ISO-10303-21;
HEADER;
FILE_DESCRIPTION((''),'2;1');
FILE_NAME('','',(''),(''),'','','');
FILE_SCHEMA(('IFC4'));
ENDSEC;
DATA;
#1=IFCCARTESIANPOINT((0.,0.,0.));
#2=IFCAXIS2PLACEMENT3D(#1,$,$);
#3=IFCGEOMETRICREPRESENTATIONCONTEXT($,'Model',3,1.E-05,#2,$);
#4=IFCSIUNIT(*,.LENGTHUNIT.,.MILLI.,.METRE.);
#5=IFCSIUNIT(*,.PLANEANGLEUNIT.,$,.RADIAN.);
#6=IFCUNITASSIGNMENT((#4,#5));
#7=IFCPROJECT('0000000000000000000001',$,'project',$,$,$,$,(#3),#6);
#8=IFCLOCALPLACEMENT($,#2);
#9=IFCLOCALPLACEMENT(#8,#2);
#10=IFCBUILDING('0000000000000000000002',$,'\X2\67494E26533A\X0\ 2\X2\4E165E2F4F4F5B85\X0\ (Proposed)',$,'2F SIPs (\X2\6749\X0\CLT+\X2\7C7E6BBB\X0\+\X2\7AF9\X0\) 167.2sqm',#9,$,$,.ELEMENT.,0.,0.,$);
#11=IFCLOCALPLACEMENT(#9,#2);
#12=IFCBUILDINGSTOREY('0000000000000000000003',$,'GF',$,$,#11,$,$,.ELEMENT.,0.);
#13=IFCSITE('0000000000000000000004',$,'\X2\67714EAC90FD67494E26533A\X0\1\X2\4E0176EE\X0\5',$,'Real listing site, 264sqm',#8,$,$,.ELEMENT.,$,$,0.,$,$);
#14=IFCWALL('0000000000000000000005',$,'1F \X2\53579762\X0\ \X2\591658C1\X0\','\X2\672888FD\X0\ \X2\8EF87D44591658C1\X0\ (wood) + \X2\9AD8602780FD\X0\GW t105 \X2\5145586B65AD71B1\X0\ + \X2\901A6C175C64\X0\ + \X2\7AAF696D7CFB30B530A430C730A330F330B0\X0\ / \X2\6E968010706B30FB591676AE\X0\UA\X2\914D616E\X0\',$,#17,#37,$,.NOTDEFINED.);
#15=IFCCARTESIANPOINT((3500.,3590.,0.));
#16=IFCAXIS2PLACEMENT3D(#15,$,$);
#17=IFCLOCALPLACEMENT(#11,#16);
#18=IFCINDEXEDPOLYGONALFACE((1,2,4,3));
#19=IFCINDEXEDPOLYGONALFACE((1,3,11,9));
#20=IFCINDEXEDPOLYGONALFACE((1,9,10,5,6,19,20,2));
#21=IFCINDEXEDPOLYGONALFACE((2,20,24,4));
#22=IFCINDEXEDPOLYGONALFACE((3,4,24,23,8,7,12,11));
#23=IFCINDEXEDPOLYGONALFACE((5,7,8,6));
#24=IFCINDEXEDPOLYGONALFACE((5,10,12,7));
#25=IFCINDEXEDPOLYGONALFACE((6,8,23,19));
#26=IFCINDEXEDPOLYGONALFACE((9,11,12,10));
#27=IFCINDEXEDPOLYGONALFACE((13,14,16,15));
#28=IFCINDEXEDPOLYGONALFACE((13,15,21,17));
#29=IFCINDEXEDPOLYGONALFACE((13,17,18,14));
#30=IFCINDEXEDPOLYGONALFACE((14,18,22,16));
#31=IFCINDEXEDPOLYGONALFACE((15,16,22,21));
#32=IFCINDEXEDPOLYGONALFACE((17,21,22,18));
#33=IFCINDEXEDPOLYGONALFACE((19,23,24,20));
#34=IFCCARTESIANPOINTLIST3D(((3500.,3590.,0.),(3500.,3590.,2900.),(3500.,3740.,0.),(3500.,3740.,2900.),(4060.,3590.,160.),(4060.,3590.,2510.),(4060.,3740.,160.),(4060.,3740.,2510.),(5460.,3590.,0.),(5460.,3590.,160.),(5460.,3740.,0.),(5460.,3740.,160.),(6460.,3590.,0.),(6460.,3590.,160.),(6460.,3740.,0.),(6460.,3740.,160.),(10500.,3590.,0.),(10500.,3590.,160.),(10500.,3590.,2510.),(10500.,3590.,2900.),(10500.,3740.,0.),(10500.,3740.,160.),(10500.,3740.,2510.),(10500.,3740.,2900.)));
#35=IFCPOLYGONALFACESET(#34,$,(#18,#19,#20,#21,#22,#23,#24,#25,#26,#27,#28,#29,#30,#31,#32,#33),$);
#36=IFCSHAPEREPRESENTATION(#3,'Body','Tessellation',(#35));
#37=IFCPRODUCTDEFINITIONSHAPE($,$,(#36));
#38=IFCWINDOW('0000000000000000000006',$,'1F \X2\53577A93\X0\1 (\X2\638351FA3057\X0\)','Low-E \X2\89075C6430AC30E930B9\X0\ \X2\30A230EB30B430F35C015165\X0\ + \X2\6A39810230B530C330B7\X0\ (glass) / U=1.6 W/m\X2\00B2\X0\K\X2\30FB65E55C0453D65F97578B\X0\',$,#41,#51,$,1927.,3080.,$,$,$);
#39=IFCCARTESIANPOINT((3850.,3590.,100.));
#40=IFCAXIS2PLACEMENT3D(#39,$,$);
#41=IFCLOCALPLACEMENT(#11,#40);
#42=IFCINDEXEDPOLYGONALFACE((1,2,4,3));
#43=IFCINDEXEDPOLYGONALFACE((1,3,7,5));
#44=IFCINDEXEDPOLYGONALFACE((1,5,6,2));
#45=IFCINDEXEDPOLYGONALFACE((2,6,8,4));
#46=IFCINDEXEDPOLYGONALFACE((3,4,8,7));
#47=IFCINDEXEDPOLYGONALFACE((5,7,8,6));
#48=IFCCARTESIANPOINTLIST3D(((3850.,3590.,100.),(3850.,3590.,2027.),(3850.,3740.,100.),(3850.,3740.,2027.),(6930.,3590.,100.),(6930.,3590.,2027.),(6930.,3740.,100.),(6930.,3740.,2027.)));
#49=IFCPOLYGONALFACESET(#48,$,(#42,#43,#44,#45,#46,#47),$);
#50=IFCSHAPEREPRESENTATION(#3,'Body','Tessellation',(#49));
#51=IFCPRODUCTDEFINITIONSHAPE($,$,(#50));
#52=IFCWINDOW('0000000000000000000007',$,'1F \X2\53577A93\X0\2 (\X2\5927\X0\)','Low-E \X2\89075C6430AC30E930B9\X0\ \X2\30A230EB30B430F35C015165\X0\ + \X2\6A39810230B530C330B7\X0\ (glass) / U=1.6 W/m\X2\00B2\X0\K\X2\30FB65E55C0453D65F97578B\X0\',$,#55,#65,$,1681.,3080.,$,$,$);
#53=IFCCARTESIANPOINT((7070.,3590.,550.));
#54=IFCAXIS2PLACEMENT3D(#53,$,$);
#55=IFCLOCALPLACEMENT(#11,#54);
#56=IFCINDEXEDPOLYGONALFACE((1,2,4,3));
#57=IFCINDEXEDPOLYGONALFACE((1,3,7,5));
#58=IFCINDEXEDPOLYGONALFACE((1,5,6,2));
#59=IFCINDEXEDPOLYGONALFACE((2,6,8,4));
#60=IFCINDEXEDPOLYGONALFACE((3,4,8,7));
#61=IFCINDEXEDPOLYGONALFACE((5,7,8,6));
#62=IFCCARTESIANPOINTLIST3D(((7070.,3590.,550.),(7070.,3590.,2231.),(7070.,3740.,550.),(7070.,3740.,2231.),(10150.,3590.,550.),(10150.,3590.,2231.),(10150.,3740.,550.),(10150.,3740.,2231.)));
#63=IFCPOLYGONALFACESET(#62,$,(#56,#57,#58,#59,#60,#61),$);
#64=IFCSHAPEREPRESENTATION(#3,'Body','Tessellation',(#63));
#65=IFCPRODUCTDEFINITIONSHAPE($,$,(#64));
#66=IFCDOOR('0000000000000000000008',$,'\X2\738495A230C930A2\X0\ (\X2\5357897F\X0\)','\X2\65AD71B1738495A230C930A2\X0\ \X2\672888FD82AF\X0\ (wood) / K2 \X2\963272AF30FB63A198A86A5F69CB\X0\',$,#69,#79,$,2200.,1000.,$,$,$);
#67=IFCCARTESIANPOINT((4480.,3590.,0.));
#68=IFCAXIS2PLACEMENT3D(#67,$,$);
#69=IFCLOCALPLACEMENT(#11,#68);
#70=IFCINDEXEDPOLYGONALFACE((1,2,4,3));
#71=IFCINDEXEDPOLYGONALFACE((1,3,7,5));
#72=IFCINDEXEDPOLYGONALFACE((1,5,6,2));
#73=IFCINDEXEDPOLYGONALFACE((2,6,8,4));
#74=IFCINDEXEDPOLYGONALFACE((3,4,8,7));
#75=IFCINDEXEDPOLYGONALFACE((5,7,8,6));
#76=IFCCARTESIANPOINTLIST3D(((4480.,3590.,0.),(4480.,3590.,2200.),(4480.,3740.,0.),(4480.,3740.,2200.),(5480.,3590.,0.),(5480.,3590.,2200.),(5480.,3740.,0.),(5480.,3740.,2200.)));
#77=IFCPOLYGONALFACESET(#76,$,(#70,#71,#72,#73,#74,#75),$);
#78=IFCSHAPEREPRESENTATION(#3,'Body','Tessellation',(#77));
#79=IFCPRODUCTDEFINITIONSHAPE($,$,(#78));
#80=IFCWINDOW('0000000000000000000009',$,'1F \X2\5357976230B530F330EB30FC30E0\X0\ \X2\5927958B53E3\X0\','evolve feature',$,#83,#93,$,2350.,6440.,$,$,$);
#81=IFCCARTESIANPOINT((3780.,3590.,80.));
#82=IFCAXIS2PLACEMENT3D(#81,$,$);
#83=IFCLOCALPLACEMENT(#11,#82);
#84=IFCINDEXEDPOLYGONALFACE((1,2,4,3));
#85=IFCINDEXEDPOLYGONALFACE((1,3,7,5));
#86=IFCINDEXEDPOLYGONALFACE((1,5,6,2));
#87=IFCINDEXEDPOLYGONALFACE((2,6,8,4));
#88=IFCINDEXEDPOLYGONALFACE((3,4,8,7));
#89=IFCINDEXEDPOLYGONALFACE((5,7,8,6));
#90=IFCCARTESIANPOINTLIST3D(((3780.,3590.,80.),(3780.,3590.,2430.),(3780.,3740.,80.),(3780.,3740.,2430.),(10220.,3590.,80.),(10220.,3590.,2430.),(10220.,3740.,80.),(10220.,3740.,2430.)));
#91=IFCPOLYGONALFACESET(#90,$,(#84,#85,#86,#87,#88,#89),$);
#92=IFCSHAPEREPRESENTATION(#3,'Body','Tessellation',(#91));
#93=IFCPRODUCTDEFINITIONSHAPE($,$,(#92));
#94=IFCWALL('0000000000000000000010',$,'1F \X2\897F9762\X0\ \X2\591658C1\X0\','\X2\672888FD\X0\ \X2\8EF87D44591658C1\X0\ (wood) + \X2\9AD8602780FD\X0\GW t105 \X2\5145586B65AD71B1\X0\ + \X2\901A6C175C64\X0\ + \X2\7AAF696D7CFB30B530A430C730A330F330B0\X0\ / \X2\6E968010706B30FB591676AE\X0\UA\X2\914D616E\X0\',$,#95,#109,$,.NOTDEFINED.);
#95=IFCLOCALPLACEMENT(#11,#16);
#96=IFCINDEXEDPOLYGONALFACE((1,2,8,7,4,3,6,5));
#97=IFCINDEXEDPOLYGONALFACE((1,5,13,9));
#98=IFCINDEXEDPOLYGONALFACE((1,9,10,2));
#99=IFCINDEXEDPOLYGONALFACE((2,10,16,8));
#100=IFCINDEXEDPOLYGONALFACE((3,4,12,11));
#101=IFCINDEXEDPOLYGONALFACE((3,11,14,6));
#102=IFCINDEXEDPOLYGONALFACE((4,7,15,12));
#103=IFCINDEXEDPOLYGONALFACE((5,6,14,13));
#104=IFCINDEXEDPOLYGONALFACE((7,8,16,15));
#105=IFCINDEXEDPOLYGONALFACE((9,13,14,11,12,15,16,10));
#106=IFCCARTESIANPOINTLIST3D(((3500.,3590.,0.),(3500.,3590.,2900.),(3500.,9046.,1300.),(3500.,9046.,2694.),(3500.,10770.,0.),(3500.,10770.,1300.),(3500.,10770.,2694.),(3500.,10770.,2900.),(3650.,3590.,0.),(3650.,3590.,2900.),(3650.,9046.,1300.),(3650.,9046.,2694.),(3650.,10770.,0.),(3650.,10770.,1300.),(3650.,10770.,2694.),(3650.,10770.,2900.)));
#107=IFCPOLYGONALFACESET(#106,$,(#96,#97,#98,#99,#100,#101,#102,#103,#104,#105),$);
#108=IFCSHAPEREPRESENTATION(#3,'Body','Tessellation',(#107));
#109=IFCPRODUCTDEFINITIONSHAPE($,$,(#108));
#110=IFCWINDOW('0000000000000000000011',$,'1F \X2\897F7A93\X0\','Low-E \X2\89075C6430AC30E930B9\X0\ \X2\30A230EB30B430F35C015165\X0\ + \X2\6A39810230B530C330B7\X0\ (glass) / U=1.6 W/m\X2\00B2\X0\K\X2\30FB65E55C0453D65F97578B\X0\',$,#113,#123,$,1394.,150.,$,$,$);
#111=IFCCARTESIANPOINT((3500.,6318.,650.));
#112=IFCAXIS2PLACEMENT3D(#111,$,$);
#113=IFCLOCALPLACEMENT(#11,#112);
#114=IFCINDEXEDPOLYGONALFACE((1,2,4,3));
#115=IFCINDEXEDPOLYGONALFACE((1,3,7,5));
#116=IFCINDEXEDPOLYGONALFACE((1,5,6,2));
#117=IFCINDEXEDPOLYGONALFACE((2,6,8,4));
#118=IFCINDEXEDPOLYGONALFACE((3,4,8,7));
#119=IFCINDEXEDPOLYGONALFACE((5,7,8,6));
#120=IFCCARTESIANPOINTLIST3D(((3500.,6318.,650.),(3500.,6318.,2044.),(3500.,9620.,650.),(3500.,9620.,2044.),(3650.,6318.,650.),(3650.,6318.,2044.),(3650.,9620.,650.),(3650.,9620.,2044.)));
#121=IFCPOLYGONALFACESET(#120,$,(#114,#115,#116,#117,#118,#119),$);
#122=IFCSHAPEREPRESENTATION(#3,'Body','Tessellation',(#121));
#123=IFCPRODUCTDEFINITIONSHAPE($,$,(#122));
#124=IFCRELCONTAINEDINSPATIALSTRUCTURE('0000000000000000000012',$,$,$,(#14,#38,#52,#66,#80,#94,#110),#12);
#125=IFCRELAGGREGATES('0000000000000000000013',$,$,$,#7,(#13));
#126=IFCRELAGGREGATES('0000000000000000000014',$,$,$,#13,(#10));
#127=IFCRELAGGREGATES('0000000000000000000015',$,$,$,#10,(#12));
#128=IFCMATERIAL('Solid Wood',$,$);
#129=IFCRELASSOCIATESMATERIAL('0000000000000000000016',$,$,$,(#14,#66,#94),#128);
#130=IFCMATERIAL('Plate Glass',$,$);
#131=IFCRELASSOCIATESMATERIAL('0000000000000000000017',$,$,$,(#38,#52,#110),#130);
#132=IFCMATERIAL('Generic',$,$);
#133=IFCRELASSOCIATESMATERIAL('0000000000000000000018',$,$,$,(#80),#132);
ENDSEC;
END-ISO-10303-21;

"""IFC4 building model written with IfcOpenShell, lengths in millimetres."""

from ifc_helpers import new_model, si_unit, frame, frame_2d, origin, place, context, project, spatial, rectangle, extrude, material, element, fill, save


model = new_model("IFC4")

# Units and contexts
model_context = context("Model", 3, precision=1e-05, world=origin())
ifc_project = project(units=[si_unit("LENGTHUNIT", "METRE", prefix="MILLI"), si_unit("PLANEANGLEUNIT", "RADIAN")], contexts=[model_context])

# Site, building, storey
site_placement = place(None, origin())
site = spatial("IfcSite", under=ifc_project, at=site_placement, Name="東京都杉並区1丁目5", ObjectType="Real listing site, 264sqm", CompositionType="ELEMENT", RefElevation=0.0)
building_placement = place(site_placement, origin())
building = spatial("IfcBuilding", under=site, at=building_placement, Name="杉並区 2世帯住宅 (Proposed)", ObjectType="2F SIPs (杉CLT+籾殻+竹) 167.2sqm", CompositionType="ELEMENT", ElevationOfRefHeight=0.0, ElevationOfTerrain=0.0)
storey_placement = place(building_placement, origin())
storey = spatial("IfcBuildingStorey", under=building, at=storey_placement, Name="GF", CompositionType="ELEMENT", Elevation=0.0)

# Shared definitions
ifc_material_1 = material(Name="Solid Wood")
ifc_material_2 = material(Name="Generic")

# Wall, openings, windows, door
wall_1_placement = place(storey_placement, frame((3500.0, 3590.0, 0.0)))
wall_1 = element("IfcWall", 1, at=wall_1_placement, inside=storey, material=ifc_material_1, Name="1F 南面 外壁", Description="木製 軸組外壁 (wood) + 高性能GW t105 充填断熱 + 通気層 + 窯業系サイディング / 準耐火・外皮UA配慮", PredefinedType="NOTDEFINED", context=model_context, shape_type="SweptSolid", body=[
    extrude(rectangle(XDim=7000.0, YDim=150.0, at=frame_2d((3500.0, 75.0))), frame((3500.0, 3590.0, 0.0)), (0.0, 0.0, 1.0), 2900.0),
])
opening_1_placement = place(storey_placement, frame((3850.0, 3590.0, 100.0)))
opening_1 = element("IfcOpeningElement", 2, at=opening_1_placement, cuts=wall_1, PredefinedType="NOTDEFINED", context=model_context, shape_type="SweptSolid", body=[
    extrude(rectangle(XDim=3080.0, YDim=150.0, at=frame_2d((1540.0, 75.0))), frame((3850.0, 3590.0, 100.0)), (0.0, 0.0, 1.0), 1927.0),
])
opening_2_placement = place(storey_placement, frame((7070.0, 3590.0, 550.0)))
opening_2 = element("IfcOpeningElement", 3, at=opening_2_placement, cuts=wall_1, PredefinedType="NOTDEFINED", context=model_context, shape_type="SweptSolid", body=[
    extrude(rectangle(XDim=3080.0, YDim=150.0, at=frame_2d((1540.0, 75.0))), frame((7070.0, 3590.0, 550.0)), (0.0, 0.0, 1.0), 1681.0),
])
opening_3_placement = place(storey_placement, frame((4480.0, 3590.0, 0.0)))
opening_3 = element("IfcOpeningElement", 4, at=opening_3_placement, cuts=wall_1, PredefinedType="NOTDEFINED", context=model_context, shape_type="SweptSolid", body=[
    extrude(rectangle(XDim=1000.0, YDim=150.0, at=frame_2d((500.0, 75.0))), frame((4480.0, 3590.0, 0.0)), (0.0, 0.0, 1.0), 2200.0),
])
opening_4_placement = place(storey_placement, frame((3780.0, 3590.0, 80.0)))
opening_4 = element("IfcOpeningElement", 5, at=opening_4_placement, cuts=wall_1, PredefinedType="NOTDEFINED", context=model_context, shape_type="SweptSolid", body=[
    extrude(rectangle(XDim=6440.0, YDim=150.0, at=frame_2d((3220.0, 75.0))), frame((3780.0, 3590.0, 80.0)), (0.0, 0.0, 1.0), 2350.0),
])
ifc_material_3 = material(Name="Plate Glass")
window_1_placement = place(storey_placement, frame((3850.0, 3590.0, 100.0)))
window_1 = element("IfcWindow", 6, at=window_1_placement, inside=storey, material=ifc_material_3, Name="1F 南窓1 (掃出し)", Description="Low-E 複層ガラス アルゴン封入 + 樹脂サッシ (glass) / U=1.6 W/m²K・日射取得型", OverallHeight=1927.0, OverallWidth=3080.0, context=model_context, shape_type="SweptSolid", body=[
    extrude(rectangle(XDim=3080.0, YDim=150.0, at=frame_2d((1540.0, 75.0))), frame((3850.0, 3590.0, 100.0)), (0.0, 0.0, 1.0), 1927.0),
])
fill(opening_1, window_1)
window_2_placement = place(storey_placement, frame((7070.0, 3590.0, 550.0)))
window_2 = element("IfcWindow", 7, at=window_2_placement, inside=storey, material=ifc_material_3, Name="1F 南窓2 (大)", Description="Low-E 複層ガラス アルゴン封入 + 樹脂サッシ (glass) / U=1.6 W/m²K・日射取得型", OverallHeight=1681.0, OverallWidth=3080.0, context=model_context, shape_type="SweptSolid", body=[
    extrude(rectangle(XDim=3080.0, YDim=150.0, at=frame_2d((1540.0, 75.0))), frame((7070.0, 3590.0, 550.0)), (0.0, 0.0, 1.0), 1681.0),
])
fill(opening_2, window_2)
door_placement = place(storey_placement, frame((4480.0, 3590.0, 0.0)))
door = element("IfcDoor", 8, at=door_placement, inside=storey, material=ifc_material_1, Name="玄関ドア (南西)", Description="断熱玄関ドア 木製芯 (wood) / K2 防犯・採風機構", OverallHeight=2200.0, OverallWidth=1000.0, context=model_context, shape_type="SweptSolid", body=[
    extrude(rectangle(XDim=1000.0, YDim=150.0, at=frame_2d((500.0, 75.0))), frame((4480.0, 3590.0, 0.0)), (0.0, 0.0, 1.0), 2200.0),
])
fill(opening_3, door)
window_3_placement = place(storey_placement, frame((3780.0, 3590.0, 80.0)))
window_3 = element("IfcWindow", 9, at=window_3_placement, inside=storey, material=ifc_material_2, Name="1F 南面サンルーム 大開口", Description="evolve feature", OverallHeight=2350.0, OverallWidth=6440.0, context=model_context, shape_type="SweptSolid", body=[
    extrude(rectangle(XDim=6440.0, YDim=150.0, at=frame_2d((3220.0, 75.0))), frame((3780.0, 3590.0, 80.0)), (0.0, 0.0, 1.0), 2350.0),
])
fill(opening_4, window_3)

# Wall, opening, window
wall_2_placement = place(storey_placement, frame((3500.0, 3590.0, 0.0)))
wall_2 = element("IfcWall", 10, at=wall_2_placement, inside=storey, material=ifc_material_1, Name="1F 西面 外壁", Description="木製 軸組外壁 (wood) + 高性能GW t105 充填断熱 + 通気層 + 窯業系サイディング / 準耐火・外皮UA配慮", PredefinedType="NOTDEFINED", context=model_context, shape_type="SweptSolid", body=[
    extrude(rectangle(XDim=150.0, YDim=7180.0, at=frame_2d((75.0, 3590.0))), frame((3500.0, 3590.0, 0.0)), (0.0, 0.0, 1.0), 2900.0),
])
opening_5_placement = place(storey_placement, frame((3500.0, 6318.0, 650.0)))
opening_5 = element("IfcOpeningElement", 11, at=opening_5_placement, cuts=wall_2, PredefinedType="NOTDEFINED", context=model_context, shape_type="SweptSolid", body=[
    extrude(rectangle(XDim=150.0, YDim=3302.0, at=frame_2d((75.0, 1651.0))), frame((3500.0, 6318.0, 650.0)), (0.0, 0.0, 1.0), 1394.0),
])
window_4_placement = place(storey_placement, frame((3500.0, 6318.0, 650.0)))
window_4 = element("IfcWindow", 12, at=window_4_placement, inside=storey, material=ifc_material_3, Name="1F 西窓", Description="Low-E 複層ガラス アルゴン封入 + 樹脂サッシ (glass) / U=1.6 W/m²K・日射取得型", OverallHeight=1394.0, OverallWidth=150.0, context=model_context, shape_type="SweptSolid", body=[
    extrude(rectangle(XDim=150.0, YDim=3302.0, at=frame_2d((75.0, 1651.0))), frame((3500.0, 6318.0, 650.0)), (0.0, 0.0, 1.0), 1394.0),
])
fill(opening_5, window_4)

save(model, "model.ifc")
